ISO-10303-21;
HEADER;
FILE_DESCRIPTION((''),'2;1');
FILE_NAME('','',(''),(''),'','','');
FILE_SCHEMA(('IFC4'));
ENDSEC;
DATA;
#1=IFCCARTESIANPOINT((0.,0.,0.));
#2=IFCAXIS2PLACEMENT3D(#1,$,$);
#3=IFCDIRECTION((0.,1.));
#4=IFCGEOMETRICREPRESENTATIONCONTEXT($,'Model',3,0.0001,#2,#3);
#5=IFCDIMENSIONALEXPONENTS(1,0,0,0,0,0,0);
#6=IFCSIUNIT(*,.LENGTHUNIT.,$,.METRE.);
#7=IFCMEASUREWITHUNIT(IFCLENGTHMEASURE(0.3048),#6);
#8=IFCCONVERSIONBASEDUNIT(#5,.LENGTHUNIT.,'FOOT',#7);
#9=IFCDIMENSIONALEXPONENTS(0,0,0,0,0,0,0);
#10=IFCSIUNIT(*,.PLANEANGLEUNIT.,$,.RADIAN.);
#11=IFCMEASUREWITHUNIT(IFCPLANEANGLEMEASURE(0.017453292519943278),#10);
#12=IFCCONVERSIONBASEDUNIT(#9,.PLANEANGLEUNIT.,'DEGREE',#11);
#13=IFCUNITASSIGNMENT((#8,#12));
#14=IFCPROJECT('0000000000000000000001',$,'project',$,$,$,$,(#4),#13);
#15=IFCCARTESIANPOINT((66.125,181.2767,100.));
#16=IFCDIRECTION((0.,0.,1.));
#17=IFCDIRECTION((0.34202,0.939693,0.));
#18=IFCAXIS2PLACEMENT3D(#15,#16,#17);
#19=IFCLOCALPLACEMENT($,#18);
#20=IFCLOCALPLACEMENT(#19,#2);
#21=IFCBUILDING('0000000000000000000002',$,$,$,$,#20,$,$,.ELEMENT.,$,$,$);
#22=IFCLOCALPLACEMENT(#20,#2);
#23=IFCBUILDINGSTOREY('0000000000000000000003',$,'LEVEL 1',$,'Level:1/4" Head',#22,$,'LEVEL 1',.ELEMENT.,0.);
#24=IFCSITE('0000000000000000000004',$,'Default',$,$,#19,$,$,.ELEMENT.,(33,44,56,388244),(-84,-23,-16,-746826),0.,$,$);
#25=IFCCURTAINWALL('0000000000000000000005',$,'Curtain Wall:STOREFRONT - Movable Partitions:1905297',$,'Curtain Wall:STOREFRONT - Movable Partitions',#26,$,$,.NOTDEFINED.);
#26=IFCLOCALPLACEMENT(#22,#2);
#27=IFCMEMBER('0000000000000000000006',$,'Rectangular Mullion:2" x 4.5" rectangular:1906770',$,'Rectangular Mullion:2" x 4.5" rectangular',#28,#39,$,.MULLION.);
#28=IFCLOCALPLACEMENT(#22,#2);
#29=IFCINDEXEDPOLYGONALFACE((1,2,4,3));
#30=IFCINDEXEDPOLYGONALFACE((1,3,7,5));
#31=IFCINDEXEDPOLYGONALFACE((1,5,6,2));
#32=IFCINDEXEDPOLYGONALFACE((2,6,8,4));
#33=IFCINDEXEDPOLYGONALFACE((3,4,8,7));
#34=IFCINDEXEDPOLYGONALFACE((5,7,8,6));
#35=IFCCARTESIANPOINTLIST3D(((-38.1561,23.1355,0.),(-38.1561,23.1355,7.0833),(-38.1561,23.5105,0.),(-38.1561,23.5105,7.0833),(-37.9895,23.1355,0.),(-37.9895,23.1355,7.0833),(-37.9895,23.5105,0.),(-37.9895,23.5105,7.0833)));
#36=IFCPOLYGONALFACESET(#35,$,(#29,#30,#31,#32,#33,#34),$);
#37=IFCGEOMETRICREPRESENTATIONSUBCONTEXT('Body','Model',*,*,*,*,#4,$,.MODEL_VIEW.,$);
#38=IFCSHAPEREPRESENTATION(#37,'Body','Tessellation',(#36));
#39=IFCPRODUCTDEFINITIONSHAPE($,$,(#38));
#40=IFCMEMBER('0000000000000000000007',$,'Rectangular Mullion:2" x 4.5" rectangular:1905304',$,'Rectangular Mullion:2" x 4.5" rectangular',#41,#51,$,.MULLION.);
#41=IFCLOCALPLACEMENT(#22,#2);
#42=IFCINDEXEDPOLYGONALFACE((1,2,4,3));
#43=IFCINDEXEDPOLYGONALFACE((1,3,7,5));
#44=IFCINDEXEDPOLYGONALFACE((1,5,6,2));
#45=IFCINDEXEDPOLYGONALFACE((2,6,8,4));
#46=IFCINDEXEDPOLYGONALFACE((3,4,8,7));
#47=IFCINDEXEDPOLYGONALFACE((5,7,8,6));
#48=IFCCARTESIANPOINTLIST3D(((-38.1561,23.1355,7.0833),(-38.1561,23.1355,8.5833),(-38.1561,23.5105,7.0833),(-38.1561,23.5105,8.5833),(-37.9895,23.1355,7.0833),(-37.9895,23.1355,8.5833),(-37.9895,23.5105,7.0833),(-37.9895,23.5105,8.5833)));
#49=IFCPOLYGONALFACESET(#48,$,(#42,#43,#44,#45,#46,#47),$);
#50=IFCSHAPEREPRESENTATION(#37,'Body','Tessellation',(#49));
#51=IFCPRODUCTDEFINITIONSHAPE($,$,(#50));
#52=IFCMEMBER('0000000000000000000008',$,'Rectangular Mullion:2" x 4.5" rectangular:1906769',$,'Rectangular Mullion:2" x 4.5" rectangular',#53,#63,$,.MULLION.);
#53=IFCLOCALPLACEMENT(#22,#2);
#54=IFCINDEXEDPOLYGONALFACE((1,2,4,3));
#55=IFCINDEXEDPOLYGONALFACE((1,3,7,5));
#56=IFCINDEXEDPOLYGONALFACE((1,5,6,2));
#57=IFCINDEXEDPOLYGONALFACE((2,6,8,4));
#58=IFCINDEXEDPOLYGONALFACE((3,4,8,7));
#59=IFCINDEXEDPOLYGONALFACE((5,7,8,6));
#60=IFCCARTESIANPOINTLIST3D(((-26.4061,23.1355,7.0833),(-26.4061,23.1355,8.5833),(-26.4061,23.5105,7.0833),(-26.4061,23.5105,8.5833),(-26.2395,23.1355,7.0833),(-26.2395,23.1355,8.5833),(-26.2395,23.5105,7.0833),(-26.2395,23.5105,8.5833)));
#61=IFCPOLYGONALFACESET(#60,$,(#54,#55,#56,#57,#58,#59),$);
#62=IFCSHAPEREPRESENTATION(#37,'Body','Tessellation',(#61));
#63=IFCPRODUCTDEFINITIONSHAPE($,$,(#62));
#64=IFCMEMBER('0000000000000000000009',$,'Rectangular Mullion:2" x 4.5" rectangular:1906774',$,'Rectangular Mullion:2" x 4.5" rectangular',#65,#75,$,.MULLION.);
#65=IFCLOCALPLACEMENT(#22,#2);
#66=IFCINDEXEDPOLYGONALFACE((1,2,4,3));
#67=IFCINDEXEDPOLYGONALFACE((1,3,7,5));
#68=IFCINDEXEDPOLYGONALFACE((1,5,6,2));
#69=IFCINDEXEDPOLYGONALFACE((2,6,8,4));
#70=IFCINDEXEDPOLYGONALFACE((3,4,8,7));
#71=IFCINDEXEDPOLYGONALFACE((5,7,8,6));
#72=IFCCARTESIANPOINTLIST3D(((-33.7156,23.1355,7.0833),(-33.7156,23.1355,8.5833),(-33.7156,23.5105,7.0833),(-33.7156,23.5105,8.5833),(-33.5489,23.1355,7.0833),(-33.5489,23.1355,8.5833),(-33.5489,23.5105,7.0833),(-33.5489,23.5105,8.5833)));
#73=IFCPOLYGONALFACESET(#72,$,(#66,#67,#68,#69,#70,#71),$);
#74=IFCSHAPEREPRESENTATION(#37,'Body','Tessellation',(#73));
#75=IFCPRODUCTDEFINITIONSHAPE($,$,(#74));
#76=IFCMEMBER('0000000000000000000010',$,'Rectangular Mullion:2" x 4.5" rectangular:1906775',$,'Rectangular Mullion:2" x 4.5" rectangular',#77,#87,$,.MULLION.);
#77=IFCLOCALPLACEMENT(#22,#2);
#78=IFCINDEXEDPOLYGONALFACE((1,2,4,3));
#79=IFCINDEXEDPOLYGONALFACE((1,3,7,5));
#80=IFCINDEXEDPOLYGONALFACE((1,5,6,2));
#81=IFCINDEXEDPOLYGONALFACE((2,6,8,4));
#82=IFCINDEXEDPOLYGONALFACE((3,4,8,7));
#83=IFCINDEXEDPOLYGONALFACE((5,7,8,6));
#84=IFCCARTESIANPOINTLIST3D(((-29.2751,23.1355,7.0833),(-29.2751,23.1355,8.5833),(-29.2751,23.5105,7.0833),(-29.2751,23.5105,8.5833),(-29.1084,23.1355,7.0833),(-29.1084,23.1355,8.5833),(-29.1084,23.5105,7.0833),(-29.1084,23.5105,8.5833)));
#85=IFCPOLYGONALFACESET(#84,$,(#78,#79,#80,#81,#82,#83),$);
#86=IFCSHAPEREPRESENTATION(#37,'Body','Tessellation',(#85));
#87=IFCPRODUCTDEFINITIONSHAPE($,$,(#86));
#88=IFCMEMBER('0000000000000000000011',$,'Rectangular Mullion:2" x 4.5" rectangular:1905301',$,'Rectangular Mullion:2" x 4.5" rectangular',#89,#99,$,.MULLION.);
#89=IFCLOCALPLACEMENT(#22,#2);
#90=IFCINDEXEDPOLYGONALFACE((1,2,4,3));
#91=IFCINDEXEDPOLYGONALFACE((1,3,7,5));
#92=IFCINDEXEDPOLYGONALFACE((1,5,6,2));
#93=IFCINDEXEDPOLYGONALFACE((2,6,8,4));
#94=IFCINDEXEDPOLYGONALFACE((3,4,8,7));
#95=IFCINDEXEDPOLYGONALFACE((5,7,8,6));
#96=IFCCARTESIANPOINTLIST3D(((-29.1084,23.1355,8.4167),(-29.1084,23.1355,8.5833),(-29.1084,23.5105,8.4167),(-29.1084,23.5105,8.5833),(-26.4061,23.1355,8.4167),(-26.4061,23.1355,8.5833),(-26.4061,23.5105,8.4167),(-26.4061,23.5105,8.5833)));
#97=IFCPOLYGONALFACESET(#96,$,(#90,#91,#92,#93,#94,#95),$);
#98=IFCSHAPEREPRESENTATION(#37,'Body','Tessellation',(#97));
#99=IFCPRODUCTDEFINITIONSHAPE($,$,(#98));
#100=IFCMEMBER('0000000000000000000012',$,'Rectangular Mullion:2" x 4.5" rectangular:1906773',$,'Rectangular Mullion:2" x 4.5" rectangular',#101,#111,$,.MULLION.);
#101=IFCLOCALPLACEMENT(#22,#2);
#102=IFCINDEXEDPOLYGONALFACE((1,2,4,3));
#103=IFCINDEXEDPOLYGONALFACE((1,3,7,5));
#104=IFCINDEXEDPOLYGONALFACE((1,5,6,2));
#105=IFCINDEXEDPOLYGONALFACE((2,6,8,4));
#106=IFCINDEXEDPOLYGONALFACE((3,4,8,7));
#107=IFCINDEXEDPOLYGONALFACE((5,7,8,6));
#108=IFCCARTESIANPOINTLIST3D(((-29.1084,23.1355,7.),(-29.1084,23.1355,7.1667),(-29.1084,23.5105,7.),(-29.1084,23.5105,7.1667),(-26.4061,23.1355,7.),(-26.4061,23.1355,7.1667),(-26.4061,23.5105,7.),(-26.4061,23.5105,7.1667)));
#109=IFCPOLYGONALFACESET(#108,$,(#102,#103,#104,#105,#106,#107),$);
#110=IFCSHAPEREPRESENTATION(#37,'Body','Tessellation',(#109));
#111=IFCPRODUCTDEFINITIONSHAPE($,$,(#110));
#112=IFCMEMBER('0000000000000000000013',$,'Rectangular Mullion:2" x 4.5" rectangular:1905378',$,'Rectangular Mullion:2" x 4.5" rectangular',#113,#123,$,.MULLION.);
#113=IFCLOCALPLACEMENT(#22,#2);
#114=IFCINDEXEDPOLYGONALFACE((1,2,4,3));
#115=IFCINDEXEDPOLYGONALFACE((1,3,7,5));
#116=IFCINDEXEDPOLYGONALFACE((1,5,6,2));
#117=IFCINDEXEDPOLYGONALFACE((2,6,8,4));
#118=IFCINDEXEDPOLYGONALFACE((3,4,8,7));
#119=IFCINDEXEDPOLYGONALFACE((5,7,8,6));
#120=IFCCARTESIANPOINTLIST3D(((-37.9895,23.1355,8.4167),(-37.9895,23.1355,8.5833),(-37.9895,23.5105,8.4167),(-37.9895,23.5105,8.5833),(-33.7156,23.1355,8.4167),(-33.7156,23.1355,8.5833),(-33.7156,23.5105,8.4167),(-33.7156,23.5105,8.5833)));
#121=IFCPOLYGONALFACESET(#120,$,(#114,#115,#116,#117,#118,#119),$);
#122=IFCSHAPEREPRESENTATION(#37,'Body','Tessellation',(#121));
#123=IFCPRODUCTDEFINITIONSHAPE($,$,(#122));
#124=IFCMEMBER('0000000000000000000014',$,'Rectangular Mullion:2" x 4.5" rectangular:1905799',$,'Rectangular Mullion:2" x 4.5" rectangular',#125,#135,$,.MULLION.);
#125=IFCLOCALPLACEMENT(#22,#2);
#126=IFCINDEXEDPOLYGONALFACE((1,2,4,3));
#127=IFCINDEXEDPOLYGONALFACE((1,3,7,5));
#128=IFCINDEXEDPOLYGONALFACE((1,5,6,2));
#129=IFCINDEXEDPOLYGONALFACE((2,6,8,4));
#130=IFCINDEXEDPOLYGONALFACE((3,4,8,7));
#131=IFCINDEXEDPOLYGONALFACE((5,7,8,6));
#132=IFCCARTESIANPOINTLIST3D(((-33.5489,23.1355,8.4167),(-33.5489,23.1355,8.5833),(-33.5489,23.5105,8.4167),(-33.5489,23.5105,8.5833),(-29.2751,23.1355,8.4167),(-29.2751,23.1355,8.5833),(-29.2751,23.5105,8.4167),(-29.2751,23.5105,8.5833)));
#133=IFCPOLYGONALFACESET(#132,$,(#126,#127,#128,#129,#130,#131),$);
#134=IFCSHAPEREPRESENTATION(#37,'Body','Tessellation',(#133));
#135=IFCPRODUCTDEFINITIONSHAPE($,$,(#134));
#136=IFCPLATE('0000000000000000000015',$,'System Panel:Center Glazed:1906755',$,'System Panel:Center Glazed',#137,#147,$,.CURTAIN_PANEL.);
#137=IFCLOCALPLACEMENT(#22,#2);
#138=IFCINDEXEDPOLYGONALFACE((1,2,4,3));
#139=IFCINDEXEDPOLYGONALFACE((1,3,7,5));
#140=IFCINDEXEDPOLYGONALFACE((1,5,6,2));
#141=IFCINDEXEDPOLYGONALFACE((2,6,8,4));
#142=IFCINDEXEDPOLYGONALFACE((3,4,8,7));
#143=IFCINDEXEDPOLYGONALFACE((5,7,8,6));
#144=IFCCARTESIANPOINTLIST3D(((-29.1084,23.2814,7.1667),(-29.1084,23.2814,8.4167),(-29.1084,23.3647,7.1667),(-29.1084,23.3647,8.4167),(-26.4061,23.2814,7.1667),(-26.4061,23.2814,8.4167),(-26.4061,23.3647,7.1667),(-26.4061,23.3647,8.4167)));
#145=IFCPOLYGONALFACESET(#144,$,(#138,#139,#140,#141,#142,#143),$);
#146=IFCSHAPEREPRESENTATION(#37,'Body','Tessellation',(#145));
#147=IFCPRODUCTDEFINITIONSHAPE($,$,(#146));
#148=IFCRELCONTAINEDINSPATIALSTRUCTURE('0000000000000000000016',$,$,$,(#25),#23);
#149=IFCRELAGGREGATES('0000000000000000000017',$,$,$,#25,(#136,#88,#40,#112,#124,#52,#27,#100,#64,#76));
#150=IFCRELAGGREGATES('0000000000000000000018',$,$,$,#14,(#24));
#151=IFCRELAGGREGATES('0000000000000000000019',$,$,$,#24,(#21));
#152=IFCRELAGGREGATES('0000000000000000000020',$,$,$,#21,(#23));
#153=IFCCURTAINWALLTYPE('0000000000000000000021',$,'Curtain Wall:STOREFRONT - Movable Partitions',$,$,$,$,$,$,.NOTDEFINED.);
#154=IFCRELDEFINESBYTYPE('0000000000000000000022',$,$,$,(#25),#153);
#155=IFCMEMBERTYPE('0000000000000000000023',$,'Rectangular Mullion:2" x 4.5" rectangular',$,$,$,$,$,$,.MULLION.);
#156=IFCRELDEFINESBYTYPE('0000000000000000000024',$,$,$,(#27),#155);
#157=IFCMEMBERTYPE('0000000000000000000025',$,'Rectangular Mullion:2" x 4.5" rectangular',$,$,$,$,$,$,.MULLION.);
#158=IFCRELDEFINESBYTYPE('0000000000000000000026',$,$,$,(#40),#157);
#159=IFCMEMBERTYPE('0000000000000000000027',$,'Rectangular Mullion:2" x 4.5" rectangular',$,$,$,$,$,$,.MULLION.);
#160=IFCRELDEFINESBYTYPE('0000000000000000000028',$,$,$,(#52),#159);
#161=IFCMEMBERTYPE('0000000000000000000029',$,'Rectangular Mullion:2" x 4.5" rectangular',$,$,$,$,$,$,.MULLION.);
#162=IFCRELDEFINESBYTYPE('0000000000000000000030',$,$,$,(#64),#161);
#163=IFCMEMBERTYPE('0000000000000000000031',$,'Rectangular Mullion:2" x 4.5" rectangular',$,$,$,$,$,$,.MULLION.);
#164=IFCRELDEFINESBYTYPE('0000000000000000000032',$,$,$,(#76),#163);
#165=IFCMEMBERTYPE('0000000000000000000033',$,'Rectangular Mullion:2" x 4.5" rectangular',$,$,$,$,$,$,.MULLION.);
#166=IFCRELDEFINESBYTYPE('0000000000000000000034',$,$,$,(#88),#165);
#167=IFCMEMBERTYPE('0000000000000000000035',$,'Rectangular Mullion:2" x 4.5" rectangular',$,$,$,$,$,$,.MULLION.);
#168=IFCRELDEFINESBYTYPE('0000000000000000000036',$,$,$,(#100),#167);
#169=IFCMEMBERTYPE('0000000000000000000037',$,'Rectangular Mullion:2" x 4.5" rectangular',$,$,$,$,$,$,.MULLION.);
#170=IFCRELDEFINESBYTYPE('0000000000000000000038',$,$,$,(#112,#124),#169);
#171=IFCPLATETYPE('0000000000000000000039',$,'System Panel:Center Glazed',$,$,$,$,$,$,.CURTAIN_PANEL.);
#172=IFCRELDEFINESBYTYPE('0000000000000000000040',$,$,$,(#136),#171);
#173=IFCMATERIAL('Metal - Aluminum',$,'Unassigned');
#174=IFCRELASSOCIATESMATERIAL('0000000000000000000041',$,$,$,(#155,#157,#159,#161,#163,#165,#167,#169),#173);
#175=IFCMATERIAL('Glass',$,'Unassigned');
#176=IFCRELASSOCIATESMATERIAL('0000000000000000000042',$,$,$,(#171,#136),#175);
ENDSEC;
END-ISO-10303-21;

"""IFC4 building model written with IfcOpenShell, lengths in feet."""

from ifc_helpers import new_model, entity, si_unit, converted_unit, direction, frame, frame_2d, origin, origin_2d_with_axis, place, context, subcontext, project, spatial, rectangle, extrude, source, transform, mapped, material, material_profile, profile_set, type_object, type_shapes, element, aggregate, save


model = new_model("IFC4")

# Units and contexts
model_context = context("Model", 3, precision=0.0001, world=origin(), true_north=direction((0.0, 1.0)))
body_context = subcontext(model_context, "Body", "Model", "MODEL_VIEW")
ifc_project = project(units=[converted_unit("LENGTHUNIT", "FOOT", entity("IfcLengthMeasure", 0.3048), si_unit("LENGTHUNIT", "METRE"), dimensions=[1, 0, 0, 0, 0, 0, 0]), converted_unit("PLANEANGLEUNIT", "DEGREE", entity("IfcPlaneAngleMeasure", 0.017453292519943278), si_unit("PLANEANGLEUNIT", "RADIAN"), dimensions=[0, 0, 0, 0, 0, 0, 0])], contexts=[model_context])

# Site, building, storey
site_placement = place(None, frame((66.125, 181.2767, 100.0), z_axis=(0.0, 0.0, 1.0), x_axis=(0.34202, 0.939693, 0.0)))
site = spatial("IfcSite", under=ifc_project, at=site_placement, Name="Default", CompositionType="ELEMENT", RefLatitude=(33, 44, 56, 388244), RefLongitude=(-84, -23, -16, -746826), RefElevation=0.0)
building_placement = place(site_placement, origin())
building = spatial("IfcBuilding", under=site, at=building_placement, CompositionType="ELEMENT")
storey_placement = place(building_placement, origin())
storey = spatial("IfcBuildingStorey", under=building, at=storey_placement, Name="LEVEL 1", ObjectType="Level:1/4\" Head", LongName="LEVEL 1", CompositionType="ELEMENT", Elevation=0.0)

# Curtain wall, members
curtain_wall_type = type_object("IfcCurtainWallType", Name="Curtain Wall:STOREFRONT - Movable Partitions", PredefinedType="NOTDEFINED")
curtain_wall_placement = place(storey_placement, origin())
curtain_wall = element("IfcCurtainWall", 1, at=curtain_wall_placement, inside=storey, type_object=curtain_wall_type, Name="Curtain Wall:STOREFRONT - Movable Partitions:1905297", ObjectType="Curtain Wall:STOREFRONT - Movable Partitions", PredefinedType="NOTDEFINED")
ifc_material_1 = material(Name="Metal - Aluminum", Category="Unassigned")
ifc_material_profile_1 = material_profile(ifc_material_1, rectangle(XDim=0.1667, YDim=0.375, at=origin_2d_with_axis()), Name="2\" x 4.5\" rectangular")
ifc_profile_set_1 = profile_set([ifc_material_profile_1], Name="2\" x 4.5\" rectangular")
member_type_1 = type_object("IfcMemberType", Name="Rectangular Mullion:2\" x 4.5\" rectangular", PredefinedType="MULLION", material=ifc_profile_set_1)
shared_shape_1 = source(origin(), body_context, "Body", "SweptSolid", [
    extrude(rectangle(XDim=0.1667, YDim=0.375, at=origin_2d_with_axis()), frame((-0.0833, 0.0, -7.0833), z_axis=(0.0, 0.0, 1.0), x_axis=(-1.0, 0.0, 0.0)), (0.0, 0.0, 1.0), 7.0833),
])
type_shapes(member_type_1, [shared_shape_1])
member_1_placement = place(curtain_wall_placement, frame((-38.1561, 23.323, 7.0833), z_axis=(0.0, 0.0, 1.0), x_axis=(-1.0, 0.0, 0.0)))
member_1 = element("IfcMember", 2, at=member_1_placement, type_object=member_type_1, Name="Rectangular Mullion:2\" x 4.5\" rectangular:1906770", ObjectType="Rectangular Mullion:2\" x 4.5\" rectangular", PredefinedType="MULLION", context=body_context, shape_type="MappedRepresentation", body=[
    mapped(shared_shape_1, transform((0.0, 0.0, 0.0), scale=1.0)),
])
member_type_2 = type_object("IfcMemberType", Name="Rectangular Mullion:2\" x 4.5\" rectangular", PredefinedType="MULLION", material=ifc_profile_set_1)
shared_shape_2 = source(origin(), body_context, "Body", "SweptSolid", [
    extrude(rectangle(XDim=0.1667, YDim=0.375, at=origin_2d_with_axis()), frame((-0.0833, 0.0, -1.5), z_axis=(0.0, 0.0, 1.0), x_axis=(-1.0, 0.0, 0.0)), (0.0, 0.0, 1.0), 1.5),
])
type_shapes(member_type_2, [shared_shape_2])
member_2_placement = place(curtain_wall_placement, frame((-38.1561, 23.323, 8.5833), z_axis=(0.0, 0.0, 1.0), x_axis=(-1.0, 0.0, 0.0)))
member_2 = element("IfcMember", 3, at=member_2_placement, type_object=member_type_2, Name="Rectangular Mullion:2\" x 4.5\" rectangular:1905304", ObjectType="Rectangular Mullion:2\" x 4.5\" rectangular", PredefinedType="MULLION", context=body_context, shape_type="MappedRepresentation", body=[
    mapped(shared_shape_2, transform((0.0, 0.0, 0.0), scale=1.0)),
])
member_type_3 = type_object("IfcMemberType", Name="Rectangular Mullion:2\" x 4.5\" rectangular", PredefinedType="MULLION", material=ifc_profile_set_1)
shared_shape_3 = source(origin(), body_context, "Body", "SweptSolid", [
    extrude(rectangle(XDim=0.1667, YDim=0.375, at=origin_2d_with_axis()), frame((-0.0833, 0.0, -1.5), z_axis=(0.0, 0.0, 1.0), x_axis=(-1.0, 0.0, 0.0)), (0.0, 0.0, 1.0), 1.5),
])
type_shapes(member_type_3, [shared_shape_3])
member_3_placement = place(curtain_wall_placement, frame((-26.2395, 23.323, 7.0833), z_axis=(0.0, 0.0, -1.0), x_axis=(1.0, 0.0, 0.0)))
member_3 = element("IfcMember", 4, at=member_3_placement, type_object=member_type_3, Name="Rectangular Mullion:2\" x 4.5\" rectangular:1906769", ObjectType="Rectangular Mullion:2\" x 4.5\" rectangular", PredefinedType="MULLION", context=body_context, shape_type="MappedRepresentation", body=[
    mapped(shared_shape_3, transform((0.0, 0.0, 0.0), scale=1.0)),
])
member_type_4 = type_object("IfcMemberType", Name="Rectangular Mullion:2\" x 4.5\" rectangular", PredefinedType="MULLION", material=ifc_profile_set_1)
shared_shape_4 = source(origin(), body_context, "Body", "SweptSolid", [
    extrude(rectangle(XDim=0.1667, YDim=0.375, at=origin_2d_with_axis()), frame((0.0, 0.0, -1.5), z_axis=(0.0, 0.0, 1.0), x_axis=(-1.0, 0.0, 0.0)), (0.0, 0.0, 1.0), 1.5),
])
type_shapes(member_type_4, [shared_shape_4])
member_4_placement = place(curtain_wall_placement, frame((-33.6323, 23.323, 7.0833), z_axis=(0.0, 0.0, -1.0), x_axis=(1.0, 0.0, 0.0)))
member_4 = element("IfcMember", 5, at=member_4_placement, type_object=member_type_4, Name="Rectangular Mullion:2\" x 4.5\" rectangular:1906774", ObjectType="Rectangular Mullion:2\" x 4.5\" rectangular", PredefinedType="MULLION", context=body_context, shape_type="MappedRepresentation", body=[
    mapped(shared_shape_4, transform((0.0, 0.0, 0.0), scale=1.0)),
])
member_type_5 = type_object("IfcMemberType", Name="Rectangular Mullion:2\" x 4.5\" rectangular", PredefinedType="MULLION", material=ifc_profile_set_1)
shared_shape_5 = source(origin(), body_context, "Body", "SweptSolid", [
    extrude(rectangle(XDim=0.1667, YDim=0.375, at=origin_2d_with_axis()), frame((0.0, 0.0, -1.5), z_axis=(0.0, 0.0, 1.0), x_axis=(-1.0, 0.0, 0.0)), (0.0, 0.0, 1.0), 1.5),
])
type_shapes(member_type_5, [shared_shape_5])
member_5_placement = place(curtain_wall_placement, frame((-29.1917, 23.323, 7.0833), z_axis=(0.0, 0.0, -1.0), x_axis=(1.0, 0.0, 0.0)))
member_5 = element("IfcMember", 6, at=member_5_placement, type_object=member_type_5, Name="Rectangular Mullion:2\" x 4.5\" rectangular:1906775", ObjectType="Rectangular Mullion:2\" x 4.5\" rectangular", PredefinedType="MULLION", context=body_context, shape_type="MappedRepresentation", body=[
    mapped(shared_shape_5, transform((0.0, 0.0, 0.0), scale=1.0)),
])
member_type_6 = type_object("IfcMemberType", Name="Rectangular Mullion:2\" x 4.5\" rectangular", PredefinedType="MULLION", material=ifc_profile_set_1)
shared_shape_6 = source(origin(), body_context, "Body", "SweptSolid", [
    extrude(rectangle(XDim=0.1667, YDim=0.375, at=origin_2d_with_axis()), frame((-0.0833, 0.0, -2.7023), z_axis=(0.0, 0.0, 1.0), x_axis=(-1.0, 0.0, 0.0)), (0.0, 0.0, 1.0), 2.7023),
])
type_shapes(member_type_6, [shared_shape_6])
member_6_placement = place(curtain_wall_placement, frame((-26.4061, 23.323, 8.5833), z_axis=(1.0, 0.0, 0.0), x_axis=(0.0, 0.0, 1.0)))
member_6 = element("IfcMember", 7, at=member_6_placement, type_object=member_type_6, Name="Rectangular Mullion:2\" x 4.5\" rectangular:1905301", ObjectType="Rectangular Mullion:2\" x 4.5\" rectangular", PredefinedType="MULLION", context=body_context, shape_type="MappedRepresentation", body=[
    mapped(shared_shape_6, transform((0.0, 0.0, 0.0), scale=1.0)),
])
member_type_7 = type_object("IfcMemberType", Name="Rectangular Mullion:2\" x 4.5\" rectangular", PredefinedType="MULLION", material=ifc_profile_set_1)
shared_shape_7 = source(origin(), body_context, "Body", "SweptSolid", [
    extrude(rectangle(XDim=0.1667, YDim=0.375, at=frame_2d((0.0, 0.0), x_axis=(1.0, 0.0))), frame((0.0, 0.0, -2.7023), z_axis=(0.0, 0.0, 1.0), x_axis=(-1.0, 0.0, 0.0)), (0.0, 0.0, 1.0), 2.7023),
])
type_shapes(member_type_7, [shared_shape_7])
member_7_placement = place(curtain_wall_placement, frame((-26.4061, 23.323, 7.0833), z_axis=(1.0, 0.0, 0.0), x_axis=(0.0, 0.0, 1.0)))
member_7 = element("IfcMember", 8, at=member_7_placement, type_object=member_type_7, Name="Rectangular Mullion:2\" x 4.5\" rectangular:1906773", ObjectType="Rectangular Mullion:2\" x 4.5\" rectangular", PredefinedType="MULLION", context=body_context, shape_type="MappedRepresentation", body=[
    mapped(shared_shape_7, transform((0.0, 0.0, 0.0), scale=1.0)),
])
member_type_8 = type_object("IfcMemberType", Name="Rectangular Mullion:2\" x 4.5\" rectangular", PredefinedType="MULLION", material=ifc_profile_set_1)
shared_shape_8 = source(origin(), body_context, "Body", "SweptSolid", [
    extrude(rectangle(XDim=0.1667, YDim=0.375, at=origin_2d_with_axis()), frame((-0.0833, 0.0, -4.2739), z_axis=(0.0, 0.0, 1.0), x_axis=(-1.0, 0.0, 0.0)), (0.0, 0.0, 1.0), 4.2739),
])
type_shapes(member_type_8, [shared_shape_8])
member_8_placement = place(curtain_wall_placement, frame((-33.7156, 23.323, 8.5833), z_axis=(1.0, 0.0, 0.0), x_axis=(0.0, 0.0, 1.0)))
member_8 = element("IfcMember", 9, at=member_8_placement, type_object=member_type_8, Name="Rectangular Mullion:2\" x 4.5\" rectangular:1905378", ObjectType="Rectangular Mullion:2\" x 4.5\" rectangular", PredefinedType="MULLION", context=body_context, shape_type="MappedRepresentation", body=[
    mapped(shared_shape_8, transform((0.0, 0.0, 0.0), scale=1.0)),
])
member_9_placement = place(curtain_wall_placement, frame((-29.2751, 23.323, 8.5833), z_axis=(1.0, 0.0, 0.0), x_axis=(0.0, 0.0, 1.0)))
member_9 = element("IfcMember", 10, at=member_9_placement, type_object=member_type_8, Name="Rectangular Mullion:2\" x 4.5\" rectangular:1905799", ObjectType="Rectangular Mullion:2\" x 4.5\" rectangular", PredefinedType="MULLION", context=body_context, shape_type="MappedRepresentation", body=[
    mapped(shared_shape_8, transform((0.0, 0.0, 0.0), scale=1.0)),
])

# Plate
ifc_material_2 = material(Name="Glass", Category="Unassigned")
plate_type = type_object("IfcPlateType", Name="System Panel:Center Glazed", PredefinedType="CURTAIN_PANEL", material=ifc_material_2)
shared_shape_9 = source(origin(), body_context, "Body", "SweptSolid", [
    extrude(rectangle(XDim=0.0833, YDim=2.7023, at=origin_2d_with_axis()), frame((0.0, 0.0, 0.0), z_axis=(0.0, 0.0, 1.0), x_axis=(0.0, 1.0, 0.0)), (0.0, 0.0, 1.0), 1.25),
])
type_shapes(plate_type, [shared_shape_9])
plate_placement = place(curtain_wall_placement, frame((-27.7573, 23.323, 7.1667)))
plate = element("IfcPlate", 11, at=plate_placement, type_object=plate_type, material=ifc_material_2, Name="System Panel:Center Glazed:1906755", ObjectType="System Panel:Center Glazed", PredefinedType="CURTAIN_PANEL", context=body_context, shape_type="MappedRepresentation", body=[
    mapped(shared_shape_9, transform((0.0, 0.0, 0.0), scale=1.0)),
])
aggregate(curtain_wall, [plate, member_6, member_2, member_8, member_9, member_3, member_1, member_7, member_4, member_5])

save(model, "model.ifc")
